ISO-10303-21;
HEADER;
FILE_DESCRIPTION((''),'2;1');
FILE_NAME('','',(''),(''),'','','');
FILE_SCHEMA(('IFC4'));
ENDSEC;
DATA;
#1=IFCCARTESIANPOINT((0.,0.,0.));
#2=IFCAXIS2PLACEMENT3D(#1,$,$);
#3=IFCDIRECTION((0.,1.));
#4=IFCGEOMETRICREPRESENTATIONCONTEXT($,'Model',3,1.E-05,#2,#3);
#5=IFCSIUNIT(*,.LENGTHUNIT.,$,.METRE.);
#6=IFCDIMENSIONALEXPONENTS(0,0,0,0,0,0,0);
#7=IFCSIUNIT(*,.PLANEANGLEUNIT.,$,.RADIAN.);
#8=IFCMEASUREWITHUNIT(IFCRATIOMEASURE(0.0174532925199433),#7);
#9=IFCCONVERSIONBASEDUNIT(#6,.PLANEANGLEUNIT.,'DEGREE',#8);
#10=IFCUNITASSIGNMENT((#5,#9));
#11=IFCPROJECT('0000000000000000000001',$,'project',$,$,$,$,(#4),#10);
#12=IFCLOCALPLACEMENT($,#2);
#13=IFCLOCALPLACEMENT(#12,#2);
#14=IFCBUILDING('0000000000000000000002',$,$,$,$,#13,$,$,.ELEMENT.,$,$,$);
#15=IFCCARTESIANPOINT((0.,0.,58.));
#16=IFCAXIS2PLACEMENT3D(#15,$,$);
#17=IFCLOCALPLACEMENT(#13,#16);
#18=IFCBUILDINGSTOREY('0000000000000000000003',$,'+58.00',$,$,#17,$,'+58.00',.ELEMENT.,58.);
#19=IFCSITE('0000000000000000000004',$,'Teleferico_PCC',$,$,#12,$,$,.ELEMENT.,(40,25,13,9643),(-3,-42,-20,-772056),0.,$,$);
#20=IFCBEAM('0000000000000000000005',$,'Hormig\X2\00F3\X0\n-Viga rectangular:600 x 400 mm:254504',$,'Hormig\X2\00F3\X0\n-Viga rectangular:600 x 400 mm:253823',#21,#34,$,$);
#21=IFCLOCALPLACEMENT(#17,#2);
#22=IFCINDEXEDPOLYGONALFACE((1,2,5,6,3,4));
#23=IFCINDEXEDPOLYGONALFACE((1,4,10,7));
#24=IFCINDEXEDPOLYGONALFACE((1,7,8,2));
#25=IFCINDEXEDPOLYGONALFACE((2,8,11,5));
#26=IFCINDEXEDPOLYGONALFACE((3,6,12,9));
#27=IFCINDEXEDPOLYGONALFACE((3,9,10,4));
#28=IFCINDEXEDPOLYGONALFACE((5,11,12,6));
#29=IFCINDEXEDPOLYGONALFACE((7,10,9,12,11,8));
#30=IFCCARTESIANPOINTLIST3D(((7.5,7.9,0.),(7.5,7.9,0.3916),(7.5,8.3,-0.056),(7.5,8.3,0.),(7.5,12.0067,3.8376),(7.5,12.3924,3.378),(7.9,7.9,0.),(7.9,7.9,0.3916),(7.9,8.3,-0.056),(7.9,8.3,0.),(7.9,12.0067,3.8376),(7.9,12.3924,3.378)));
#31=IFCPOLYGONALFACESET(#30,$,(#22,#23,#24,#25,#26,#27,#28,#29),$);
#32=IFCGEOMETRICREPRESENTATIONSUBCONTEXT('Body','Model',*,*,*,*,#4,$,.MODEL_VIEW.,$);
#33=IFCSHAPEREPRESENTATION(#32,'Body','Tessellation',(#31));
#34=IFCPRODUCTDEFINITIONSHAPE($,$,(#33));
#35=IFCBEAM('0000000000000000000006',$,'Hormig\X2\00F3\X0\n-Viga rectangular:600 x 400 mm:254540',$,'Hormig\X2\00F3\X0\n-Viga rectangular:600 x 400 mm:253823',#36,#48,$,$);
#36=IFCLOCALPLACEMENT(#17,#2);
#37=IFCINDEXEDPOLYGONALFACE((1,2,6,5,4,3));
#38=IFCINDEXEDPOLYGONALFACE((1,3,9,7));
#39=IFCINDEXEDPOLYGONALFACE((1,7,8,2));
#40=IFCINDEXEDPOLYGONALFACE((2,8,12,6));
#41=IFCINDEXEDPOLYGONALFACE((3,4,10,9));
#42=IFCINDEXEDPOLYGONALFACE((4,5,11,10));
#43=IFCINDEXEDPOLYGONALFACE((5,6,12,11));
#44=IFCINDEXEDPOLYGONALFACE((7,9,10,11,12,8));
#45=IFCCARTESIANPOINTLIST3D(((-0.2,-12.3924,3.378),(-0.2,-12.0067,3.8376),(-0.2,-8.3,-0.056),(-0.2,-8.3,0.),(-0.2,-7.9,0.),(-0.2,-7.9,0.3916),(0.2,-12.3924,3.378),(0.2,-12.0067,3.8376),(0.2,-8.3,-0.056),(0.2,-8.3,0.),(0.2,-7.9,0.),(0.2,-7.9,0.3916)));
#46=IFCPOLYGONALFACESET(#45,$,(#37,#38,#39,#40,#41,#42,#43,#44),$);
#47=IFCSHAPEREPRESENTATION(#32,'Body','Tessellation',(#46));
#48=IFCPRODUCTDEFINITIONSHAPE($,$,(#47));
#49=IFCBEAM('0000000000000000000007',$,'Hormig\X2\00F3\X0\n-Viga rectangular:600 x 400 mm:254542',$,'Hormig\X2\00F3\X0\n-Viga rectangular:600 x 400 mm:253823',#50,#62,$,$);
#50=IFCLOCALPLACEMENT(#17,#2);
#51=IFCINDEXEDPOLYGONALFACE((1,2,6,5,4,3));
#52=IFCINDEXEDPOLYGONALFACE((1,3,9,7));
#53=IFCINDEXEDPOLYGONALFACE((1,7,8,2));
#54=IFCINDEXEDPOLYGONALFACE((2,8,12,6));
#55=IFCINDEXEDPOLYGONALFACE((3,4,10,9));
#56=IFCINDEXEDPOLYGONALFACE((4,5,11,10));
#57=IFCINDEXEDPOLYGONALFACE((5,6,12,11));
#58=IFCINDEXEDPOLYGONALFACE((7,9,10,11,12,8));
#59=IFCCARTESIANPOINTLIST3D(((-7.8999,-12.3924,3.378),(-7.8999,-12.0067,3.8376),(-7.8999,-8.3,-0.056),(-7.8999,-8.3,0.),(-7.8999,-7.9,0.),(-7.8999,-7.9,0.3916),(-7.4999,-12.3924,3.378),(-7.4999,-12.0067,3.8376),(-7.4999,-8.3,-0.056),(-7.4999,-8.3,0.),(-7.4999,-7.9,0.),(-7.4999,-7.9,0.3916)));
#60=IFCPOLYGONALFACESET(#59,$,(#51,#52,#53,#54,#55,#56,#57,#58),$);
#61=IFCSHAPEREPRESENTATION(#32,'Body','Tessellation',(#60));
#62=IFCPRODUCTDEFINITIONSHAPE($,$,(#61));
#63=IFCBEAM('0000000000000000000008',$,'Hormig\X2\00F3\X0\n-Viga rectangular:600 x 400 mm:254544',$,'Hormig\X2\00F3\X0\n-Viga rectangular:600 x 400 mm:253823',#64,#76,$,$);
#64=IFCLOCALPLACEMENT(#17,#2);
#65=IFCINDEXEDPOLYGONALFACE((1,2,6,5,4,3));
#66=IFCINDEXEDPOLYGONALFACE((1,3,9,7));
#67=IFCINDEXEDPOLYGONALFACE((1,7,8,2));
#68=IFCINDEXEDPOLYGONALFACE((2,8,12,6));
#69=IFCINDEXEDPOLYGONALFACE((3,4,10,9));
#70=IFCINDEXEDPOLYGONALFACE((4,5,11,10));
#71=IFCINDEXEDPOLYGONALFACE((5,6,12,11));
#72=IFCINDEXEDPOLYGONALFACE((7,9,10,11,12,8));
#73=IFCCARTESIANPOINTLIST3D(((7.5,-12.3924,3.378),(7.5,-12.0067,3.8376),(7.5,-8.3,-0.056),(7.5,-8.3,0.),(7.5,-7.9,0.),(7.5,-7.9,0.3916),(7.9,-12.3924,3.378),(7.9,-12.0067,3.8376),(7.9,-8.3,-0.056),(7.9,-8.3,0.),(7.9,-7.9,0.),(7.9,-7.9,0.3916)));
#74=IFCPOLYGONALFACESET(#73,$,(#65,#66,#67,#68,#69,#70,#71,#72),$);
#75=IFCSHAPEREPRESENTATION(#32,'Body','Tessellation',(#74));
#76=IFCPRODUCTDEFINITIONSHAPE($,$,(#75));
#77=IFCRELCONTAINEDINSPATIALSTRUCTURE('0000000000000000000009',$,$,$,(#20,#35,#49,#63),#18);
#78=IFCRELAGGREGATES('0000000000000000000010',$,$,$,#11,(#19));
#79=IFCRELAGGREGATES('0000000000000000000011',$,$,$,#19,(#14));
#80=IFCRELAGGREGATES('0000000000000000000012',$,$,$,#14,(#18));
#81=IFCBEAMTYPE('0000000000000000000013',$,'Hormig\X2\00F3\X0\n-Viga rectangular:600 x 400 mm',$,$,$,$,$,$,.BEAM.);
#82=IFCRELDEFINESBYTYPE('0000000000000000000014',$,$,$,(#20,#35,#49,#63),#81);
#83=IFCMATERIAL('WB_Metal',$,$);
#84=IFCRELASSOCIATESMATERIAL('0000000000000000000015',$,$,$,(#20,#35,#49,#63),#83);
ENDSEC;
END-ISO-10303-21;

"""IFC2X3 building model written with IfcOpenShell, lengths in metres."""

from ifc_helpers import new_model, entity, si_unit, converted_unit, direction, frame, frame_2d, origin, place, context, subcontext, project, spatial, polyline, rectangle, extrude, clip, halfspace, bounded_halfspace, material, type_object, element, save


model = new_model("IFC2X3")

# Units and contexts
model_context = context("Model", 3, precision=1e-05, world=origin(), true_north=direction((0.0, 1.0)))
body_context = subcontext(model_context, "Body", "Model", "MODEL_VIEW")
ifc_project = project(units=[si_unit("LENGTHUNIT", "METRE"), converted_unit("PLANEANGLEUNIT", "DEGREE", entity("IfcRatioMeasure", 0.0174532925199433), si_unit("PLANEANGLEUNIT", "RADIAN"), dimensions=[0, 0, 0, 0, 0, 0, 0])], contexts=[model_context])

# Site, building, storey
site_placement = place(None, origin())
site = spatial("IfcSite", under=ifc_project, at=site_placement, Name="Teleferico_PCC", CompositionType="ELEMENT", RefLatitude=(40, 25, 13, 9643), RefLongitude=(-3, -42, -20, -772056), RefElevation=0.0)
building_placement = place(site_placement, origin())
building = spatial("IfcBuilding", under=site, at=building_placement, CompositionType="ELEMENT")
storey_placement = place(building_placement, frame((0.0, 0.0, 58.0)))
storey = spatial("IfcBuildingStorey", under=building, at=storey_placement, Name="+58.00", LongName="+58.00", CompositionType="ELEMENT", Elevation=58.0)

# Beams
ifc_material = material(Name="WB_Metal")
beam_type_1 = type_object("IfcBeamType", Name="Hormigón-Viga rectangular:600 x 400 mm", PredefinedType="BEAM")
beam_1_placement = place(storey_placement, frame((7.7, 7.9, 0.0), z_axis=(0.0, -0.642788, 0.766044), x_axis=(0.0, 0.766044, 0.642788)))
element("IfcBeam", 1, at=beam_1_placement, inside=storey, type_object=beam_type_1, material=ifc_material, Name="Hormigón-Viga rectangular:600 x 400 mm:254504", ObjectType="Hormigón-Viga rectangular:600 x 400 mm:253823", context=body_context, shape_type="Clipping", body=[
    clip(clip(clip(extrude(rectangle(XDim=0.6, YDim=0.4, at=frame_2d((0.0, 0.0), x_axis=(0.0, 1.0))), frame((0.0, 0.0, 0.0), z_axis=(1.0, 0.0, 0.0), x_axis=(0.0, 1.0, 0.0)), (0.0, 0.0, 1.0), 5.6127), halfspace(frame((0.0, 15.6, 0.0), z_axis=(-0.766044, 0.0, 0.642788), x_axis=(0.642788, 0.0, 0.766044)), False)), bounded_halfspace(frame((0.3064, 0.2, -0.2571), z_axis=(-0.642788, 0.0, -0.766044), x_axis=(0.0, 1.0, 0.0)), False, frame((0.0, 0.0, 0.0), z_axis=(1.0, 0.0, 0.0), x_axis=(0.0, 1.0, 0.0)), polyline([(0.2, -0.2571), (-0.2, -0.2571), (-0.2, 0.0), (0.2, 0.0), (0.2, -0.2571)]))), bounded_halfspace(frame((-0.2078, 0.2, -0.87), z_axis=(-0.766044, 0.0, 0.642788), x_axis=(0.0, 1.0, 0.0)), False, frame((0.0, 0.0, 0.0), z_axis=(1.0, 0.0, 0.0), x_axis=(0.0, 1.0, 0.0)), polyline([(-0.2, -0.2571), (0.2, -0.2571), (0.2, -0.3), (-0.2, -0.3), (-0.2, -0.2571)]))),
])
beam_2_placement = place(storey_placement, frame((0.0, -7.9, 0.0), z_axis=(0.0, 0.642788, 0.766044), x_axis=(0.0, -0.766044, 0.642788)))
element("IfcBeam", 2, at=beam_2_placement, inside=storey, type_object=beam_type_1, material=ifc_material, Name="Hormigón-Viga rectangular:600 x 400 mm:254540", ObjectType="Hormigón-Viga rectangular:600 x 400 mm:253823", context=body_context, shape_type="Clipping", body=[
    clip(clip(clip(extrude(rectangle(XDim=0.6, YDim=0.4, at=frame_2d((0.0, 0.0), x_axis=(0.0, 1.0))), frame((0.0, 0.0, 0.0), z_axis=(1.0, 0.0, 0.0), x_axis=(0.0, 1.0, 0.0)), (0.0, 0.0, 1.0), 5.6127), halfspace(frame((0.0, 7.9, 0.0), z_axis=(-0.766044, 0.0, 0.642788), x_axis=(0.642788, 0.0, 0.766044)), False)), bounded_halfspace(frame((0.3064, -7.499, -0.2571), z_axis=(-0.642788, 0.0, -0.766044), x_axis=(0.0, 1.0, 0.0)), False, frame((0.0, 0.0, 0.0), z_axis=(1.0, 0.0, 0.0), x_axis=(0.0, 1.0, 0.0)), polyline([(0.2, -0.2571), (-0.2, -0.2571), (-0.2, 0.0), (0.2, 0.0), (0.2, -0.2571)]))), bounded_halfspace(frame((-0.2078, -7.499, -0.87), z_axis=(-0.766044, 0.0, 0.642788), x_axis=(0.0, 1.0, 0.0)), False, frame((0.0, 0.0, 0.0), z_axis=(1.0, 0.0, 0.0), x_axis=(0.0, 1.0, 0.0)), polyline([(-0.2, -0.2571), (0.2, -0.2571), (0.2, -0.3), (-0.2, -0.3), (-0.2, -0.2571)]))),
])
beam_3_placement = place(storey_placement, frame((-7.6999, -7.9, 0.0), z_axis=(0.0, 0.642788, 0.766044), x_axis=(0.0, -0.766044, 0.642788)))
element("IfcBeam", 3, at=beam_3_placement, inside=storey, type_object=beam_type_1, material=ifc_material, Name="Hormigón-Viga rectangular:600 x 400 mm:254542", ObjectType="Hormigón-Viga rectangular:600 x 400 mm:253823", context=body_context, shape_type="Clipping", body=[
    clip(clip(clip(extrude(rectangle(XDim=0.6, YDim=0.4, at=frame_2d((0.0, 0.0), x_axis=(0.0, 1.0))), frame((0.0, 0.0, 0.0), z_axis=(1.0, 0.0, 0.0), x_axis=(0.0, 1.0, 0.0)), (0.0, 0.0, 1.0), 5.6127), halfspace(frame((0.0, 15.5999, 0.0), z_axis=(-0.766044, 0.0, 0.642788), x_axis=(0.642788, 0.0, 0.766044)), False)), bounded_halfspace(frame((0.3064, 0.2009, -0.2571), z_axis=(-0.642788, 0.0, -0.766044), x_axis=(0.0, 1.0, 0.0)), False, frame((0.0, 0.0, 0.0), z_axis=(1.0, 0.0, 0.0), x_axis=(0.0, 1.0, 0.0)), polyline([(0.2, 0.0), (0.2, -0.2571), (-0.2, -0.2571), (-0.2, 0.0), (0.2, 0.0)]))), bounded_halfspace(frame((-0.2078, 0.2009, -0.87), z_axis=(-0.766044, 0.0, 0.642788), x_axis=(0.0, 1.0, 0.0)), False, frame((0.0, 0.0, 0.0), z_axis=(1.0, 0.0, 0.0), x_axis=(0.0, 1.0, 0.0)), polyline([(0.2, -0.2571), (0.2, -0.3), (-0.2, -0.3), (-0.2, -0.2571), (0.2, -0.2571)]))),
])
beam_4_placement = place(storey_placement, frame((7.7, -7.9, 0.0), z_axis=(0.0, 0.642788, 0.766044), x_axis=(0.0, -0.766044, 0.642788)))
element("IfcBeam", 4, at=beam_4_placement, inside=storey, type_object=beam_type_1, material=ifc_material, Name="Hormigón-Viga rectangular:600 x 400 mm:254544", ObjectType="Hormigón-Viga rectangular:600 x 400 mm:253823", context=body_context, shape_type="Clipping", body=[
    clip(clip(clip(extrude(rectangle(XDim=0.6, YDim=0.4, at=frame_2d((0.0, 0.0), x_axis=(0.0, 1.0))), frame((0.0, 0.0, 0.0), z_axis=(1.0, 0.0, 0.0), x_axis=(0.0, 1.0, 0.0)), (0.0, 0.0, 1.0), 5.6127), halfspace(frame((0.0, 0.2, 0.0), z_axis=(-0.766044, 0.0, 0.642788), x_axis=(0.642788, 0.0, 0.766044)), False)), bounded_halfspace(frame((-0.3064, 0.6, 0.2571), z_axis=(-0.642788, 0.0, -0.766044), x_axis=(-0.766044, 0.0, 0.642788)), False, frame((0.0, 0.0, 0.0), z_axis=(1.0, 0.0, 0.0), x_axis=(0.0, 1.0, 0.0)), polyline([(0.2, -0.2571), (-0.2, -0.2571), (-0.2, 0.0), (0.2, 0.0), (0.2, -0.2571)]))), bounded_halfspace(frame((0.3064, 0.6239, -0.2571), z_axis=(-0.766044, 0.0, 0.642788), x_axis=(0.0, -1.0, 0.0)), False, frame((0.0, 0.0, 0.0), z_axis=(1.0, 0.0, 0.0), x_axis=(0.0, 1.0, 0.0)), polyline([(-0.2, -0.2571), (0.2, -0.2571), (0.2, -0.3), (-0.2, -0.3), (-0.2, -0.2571)]))),
])

save(model, "model.ifc")
